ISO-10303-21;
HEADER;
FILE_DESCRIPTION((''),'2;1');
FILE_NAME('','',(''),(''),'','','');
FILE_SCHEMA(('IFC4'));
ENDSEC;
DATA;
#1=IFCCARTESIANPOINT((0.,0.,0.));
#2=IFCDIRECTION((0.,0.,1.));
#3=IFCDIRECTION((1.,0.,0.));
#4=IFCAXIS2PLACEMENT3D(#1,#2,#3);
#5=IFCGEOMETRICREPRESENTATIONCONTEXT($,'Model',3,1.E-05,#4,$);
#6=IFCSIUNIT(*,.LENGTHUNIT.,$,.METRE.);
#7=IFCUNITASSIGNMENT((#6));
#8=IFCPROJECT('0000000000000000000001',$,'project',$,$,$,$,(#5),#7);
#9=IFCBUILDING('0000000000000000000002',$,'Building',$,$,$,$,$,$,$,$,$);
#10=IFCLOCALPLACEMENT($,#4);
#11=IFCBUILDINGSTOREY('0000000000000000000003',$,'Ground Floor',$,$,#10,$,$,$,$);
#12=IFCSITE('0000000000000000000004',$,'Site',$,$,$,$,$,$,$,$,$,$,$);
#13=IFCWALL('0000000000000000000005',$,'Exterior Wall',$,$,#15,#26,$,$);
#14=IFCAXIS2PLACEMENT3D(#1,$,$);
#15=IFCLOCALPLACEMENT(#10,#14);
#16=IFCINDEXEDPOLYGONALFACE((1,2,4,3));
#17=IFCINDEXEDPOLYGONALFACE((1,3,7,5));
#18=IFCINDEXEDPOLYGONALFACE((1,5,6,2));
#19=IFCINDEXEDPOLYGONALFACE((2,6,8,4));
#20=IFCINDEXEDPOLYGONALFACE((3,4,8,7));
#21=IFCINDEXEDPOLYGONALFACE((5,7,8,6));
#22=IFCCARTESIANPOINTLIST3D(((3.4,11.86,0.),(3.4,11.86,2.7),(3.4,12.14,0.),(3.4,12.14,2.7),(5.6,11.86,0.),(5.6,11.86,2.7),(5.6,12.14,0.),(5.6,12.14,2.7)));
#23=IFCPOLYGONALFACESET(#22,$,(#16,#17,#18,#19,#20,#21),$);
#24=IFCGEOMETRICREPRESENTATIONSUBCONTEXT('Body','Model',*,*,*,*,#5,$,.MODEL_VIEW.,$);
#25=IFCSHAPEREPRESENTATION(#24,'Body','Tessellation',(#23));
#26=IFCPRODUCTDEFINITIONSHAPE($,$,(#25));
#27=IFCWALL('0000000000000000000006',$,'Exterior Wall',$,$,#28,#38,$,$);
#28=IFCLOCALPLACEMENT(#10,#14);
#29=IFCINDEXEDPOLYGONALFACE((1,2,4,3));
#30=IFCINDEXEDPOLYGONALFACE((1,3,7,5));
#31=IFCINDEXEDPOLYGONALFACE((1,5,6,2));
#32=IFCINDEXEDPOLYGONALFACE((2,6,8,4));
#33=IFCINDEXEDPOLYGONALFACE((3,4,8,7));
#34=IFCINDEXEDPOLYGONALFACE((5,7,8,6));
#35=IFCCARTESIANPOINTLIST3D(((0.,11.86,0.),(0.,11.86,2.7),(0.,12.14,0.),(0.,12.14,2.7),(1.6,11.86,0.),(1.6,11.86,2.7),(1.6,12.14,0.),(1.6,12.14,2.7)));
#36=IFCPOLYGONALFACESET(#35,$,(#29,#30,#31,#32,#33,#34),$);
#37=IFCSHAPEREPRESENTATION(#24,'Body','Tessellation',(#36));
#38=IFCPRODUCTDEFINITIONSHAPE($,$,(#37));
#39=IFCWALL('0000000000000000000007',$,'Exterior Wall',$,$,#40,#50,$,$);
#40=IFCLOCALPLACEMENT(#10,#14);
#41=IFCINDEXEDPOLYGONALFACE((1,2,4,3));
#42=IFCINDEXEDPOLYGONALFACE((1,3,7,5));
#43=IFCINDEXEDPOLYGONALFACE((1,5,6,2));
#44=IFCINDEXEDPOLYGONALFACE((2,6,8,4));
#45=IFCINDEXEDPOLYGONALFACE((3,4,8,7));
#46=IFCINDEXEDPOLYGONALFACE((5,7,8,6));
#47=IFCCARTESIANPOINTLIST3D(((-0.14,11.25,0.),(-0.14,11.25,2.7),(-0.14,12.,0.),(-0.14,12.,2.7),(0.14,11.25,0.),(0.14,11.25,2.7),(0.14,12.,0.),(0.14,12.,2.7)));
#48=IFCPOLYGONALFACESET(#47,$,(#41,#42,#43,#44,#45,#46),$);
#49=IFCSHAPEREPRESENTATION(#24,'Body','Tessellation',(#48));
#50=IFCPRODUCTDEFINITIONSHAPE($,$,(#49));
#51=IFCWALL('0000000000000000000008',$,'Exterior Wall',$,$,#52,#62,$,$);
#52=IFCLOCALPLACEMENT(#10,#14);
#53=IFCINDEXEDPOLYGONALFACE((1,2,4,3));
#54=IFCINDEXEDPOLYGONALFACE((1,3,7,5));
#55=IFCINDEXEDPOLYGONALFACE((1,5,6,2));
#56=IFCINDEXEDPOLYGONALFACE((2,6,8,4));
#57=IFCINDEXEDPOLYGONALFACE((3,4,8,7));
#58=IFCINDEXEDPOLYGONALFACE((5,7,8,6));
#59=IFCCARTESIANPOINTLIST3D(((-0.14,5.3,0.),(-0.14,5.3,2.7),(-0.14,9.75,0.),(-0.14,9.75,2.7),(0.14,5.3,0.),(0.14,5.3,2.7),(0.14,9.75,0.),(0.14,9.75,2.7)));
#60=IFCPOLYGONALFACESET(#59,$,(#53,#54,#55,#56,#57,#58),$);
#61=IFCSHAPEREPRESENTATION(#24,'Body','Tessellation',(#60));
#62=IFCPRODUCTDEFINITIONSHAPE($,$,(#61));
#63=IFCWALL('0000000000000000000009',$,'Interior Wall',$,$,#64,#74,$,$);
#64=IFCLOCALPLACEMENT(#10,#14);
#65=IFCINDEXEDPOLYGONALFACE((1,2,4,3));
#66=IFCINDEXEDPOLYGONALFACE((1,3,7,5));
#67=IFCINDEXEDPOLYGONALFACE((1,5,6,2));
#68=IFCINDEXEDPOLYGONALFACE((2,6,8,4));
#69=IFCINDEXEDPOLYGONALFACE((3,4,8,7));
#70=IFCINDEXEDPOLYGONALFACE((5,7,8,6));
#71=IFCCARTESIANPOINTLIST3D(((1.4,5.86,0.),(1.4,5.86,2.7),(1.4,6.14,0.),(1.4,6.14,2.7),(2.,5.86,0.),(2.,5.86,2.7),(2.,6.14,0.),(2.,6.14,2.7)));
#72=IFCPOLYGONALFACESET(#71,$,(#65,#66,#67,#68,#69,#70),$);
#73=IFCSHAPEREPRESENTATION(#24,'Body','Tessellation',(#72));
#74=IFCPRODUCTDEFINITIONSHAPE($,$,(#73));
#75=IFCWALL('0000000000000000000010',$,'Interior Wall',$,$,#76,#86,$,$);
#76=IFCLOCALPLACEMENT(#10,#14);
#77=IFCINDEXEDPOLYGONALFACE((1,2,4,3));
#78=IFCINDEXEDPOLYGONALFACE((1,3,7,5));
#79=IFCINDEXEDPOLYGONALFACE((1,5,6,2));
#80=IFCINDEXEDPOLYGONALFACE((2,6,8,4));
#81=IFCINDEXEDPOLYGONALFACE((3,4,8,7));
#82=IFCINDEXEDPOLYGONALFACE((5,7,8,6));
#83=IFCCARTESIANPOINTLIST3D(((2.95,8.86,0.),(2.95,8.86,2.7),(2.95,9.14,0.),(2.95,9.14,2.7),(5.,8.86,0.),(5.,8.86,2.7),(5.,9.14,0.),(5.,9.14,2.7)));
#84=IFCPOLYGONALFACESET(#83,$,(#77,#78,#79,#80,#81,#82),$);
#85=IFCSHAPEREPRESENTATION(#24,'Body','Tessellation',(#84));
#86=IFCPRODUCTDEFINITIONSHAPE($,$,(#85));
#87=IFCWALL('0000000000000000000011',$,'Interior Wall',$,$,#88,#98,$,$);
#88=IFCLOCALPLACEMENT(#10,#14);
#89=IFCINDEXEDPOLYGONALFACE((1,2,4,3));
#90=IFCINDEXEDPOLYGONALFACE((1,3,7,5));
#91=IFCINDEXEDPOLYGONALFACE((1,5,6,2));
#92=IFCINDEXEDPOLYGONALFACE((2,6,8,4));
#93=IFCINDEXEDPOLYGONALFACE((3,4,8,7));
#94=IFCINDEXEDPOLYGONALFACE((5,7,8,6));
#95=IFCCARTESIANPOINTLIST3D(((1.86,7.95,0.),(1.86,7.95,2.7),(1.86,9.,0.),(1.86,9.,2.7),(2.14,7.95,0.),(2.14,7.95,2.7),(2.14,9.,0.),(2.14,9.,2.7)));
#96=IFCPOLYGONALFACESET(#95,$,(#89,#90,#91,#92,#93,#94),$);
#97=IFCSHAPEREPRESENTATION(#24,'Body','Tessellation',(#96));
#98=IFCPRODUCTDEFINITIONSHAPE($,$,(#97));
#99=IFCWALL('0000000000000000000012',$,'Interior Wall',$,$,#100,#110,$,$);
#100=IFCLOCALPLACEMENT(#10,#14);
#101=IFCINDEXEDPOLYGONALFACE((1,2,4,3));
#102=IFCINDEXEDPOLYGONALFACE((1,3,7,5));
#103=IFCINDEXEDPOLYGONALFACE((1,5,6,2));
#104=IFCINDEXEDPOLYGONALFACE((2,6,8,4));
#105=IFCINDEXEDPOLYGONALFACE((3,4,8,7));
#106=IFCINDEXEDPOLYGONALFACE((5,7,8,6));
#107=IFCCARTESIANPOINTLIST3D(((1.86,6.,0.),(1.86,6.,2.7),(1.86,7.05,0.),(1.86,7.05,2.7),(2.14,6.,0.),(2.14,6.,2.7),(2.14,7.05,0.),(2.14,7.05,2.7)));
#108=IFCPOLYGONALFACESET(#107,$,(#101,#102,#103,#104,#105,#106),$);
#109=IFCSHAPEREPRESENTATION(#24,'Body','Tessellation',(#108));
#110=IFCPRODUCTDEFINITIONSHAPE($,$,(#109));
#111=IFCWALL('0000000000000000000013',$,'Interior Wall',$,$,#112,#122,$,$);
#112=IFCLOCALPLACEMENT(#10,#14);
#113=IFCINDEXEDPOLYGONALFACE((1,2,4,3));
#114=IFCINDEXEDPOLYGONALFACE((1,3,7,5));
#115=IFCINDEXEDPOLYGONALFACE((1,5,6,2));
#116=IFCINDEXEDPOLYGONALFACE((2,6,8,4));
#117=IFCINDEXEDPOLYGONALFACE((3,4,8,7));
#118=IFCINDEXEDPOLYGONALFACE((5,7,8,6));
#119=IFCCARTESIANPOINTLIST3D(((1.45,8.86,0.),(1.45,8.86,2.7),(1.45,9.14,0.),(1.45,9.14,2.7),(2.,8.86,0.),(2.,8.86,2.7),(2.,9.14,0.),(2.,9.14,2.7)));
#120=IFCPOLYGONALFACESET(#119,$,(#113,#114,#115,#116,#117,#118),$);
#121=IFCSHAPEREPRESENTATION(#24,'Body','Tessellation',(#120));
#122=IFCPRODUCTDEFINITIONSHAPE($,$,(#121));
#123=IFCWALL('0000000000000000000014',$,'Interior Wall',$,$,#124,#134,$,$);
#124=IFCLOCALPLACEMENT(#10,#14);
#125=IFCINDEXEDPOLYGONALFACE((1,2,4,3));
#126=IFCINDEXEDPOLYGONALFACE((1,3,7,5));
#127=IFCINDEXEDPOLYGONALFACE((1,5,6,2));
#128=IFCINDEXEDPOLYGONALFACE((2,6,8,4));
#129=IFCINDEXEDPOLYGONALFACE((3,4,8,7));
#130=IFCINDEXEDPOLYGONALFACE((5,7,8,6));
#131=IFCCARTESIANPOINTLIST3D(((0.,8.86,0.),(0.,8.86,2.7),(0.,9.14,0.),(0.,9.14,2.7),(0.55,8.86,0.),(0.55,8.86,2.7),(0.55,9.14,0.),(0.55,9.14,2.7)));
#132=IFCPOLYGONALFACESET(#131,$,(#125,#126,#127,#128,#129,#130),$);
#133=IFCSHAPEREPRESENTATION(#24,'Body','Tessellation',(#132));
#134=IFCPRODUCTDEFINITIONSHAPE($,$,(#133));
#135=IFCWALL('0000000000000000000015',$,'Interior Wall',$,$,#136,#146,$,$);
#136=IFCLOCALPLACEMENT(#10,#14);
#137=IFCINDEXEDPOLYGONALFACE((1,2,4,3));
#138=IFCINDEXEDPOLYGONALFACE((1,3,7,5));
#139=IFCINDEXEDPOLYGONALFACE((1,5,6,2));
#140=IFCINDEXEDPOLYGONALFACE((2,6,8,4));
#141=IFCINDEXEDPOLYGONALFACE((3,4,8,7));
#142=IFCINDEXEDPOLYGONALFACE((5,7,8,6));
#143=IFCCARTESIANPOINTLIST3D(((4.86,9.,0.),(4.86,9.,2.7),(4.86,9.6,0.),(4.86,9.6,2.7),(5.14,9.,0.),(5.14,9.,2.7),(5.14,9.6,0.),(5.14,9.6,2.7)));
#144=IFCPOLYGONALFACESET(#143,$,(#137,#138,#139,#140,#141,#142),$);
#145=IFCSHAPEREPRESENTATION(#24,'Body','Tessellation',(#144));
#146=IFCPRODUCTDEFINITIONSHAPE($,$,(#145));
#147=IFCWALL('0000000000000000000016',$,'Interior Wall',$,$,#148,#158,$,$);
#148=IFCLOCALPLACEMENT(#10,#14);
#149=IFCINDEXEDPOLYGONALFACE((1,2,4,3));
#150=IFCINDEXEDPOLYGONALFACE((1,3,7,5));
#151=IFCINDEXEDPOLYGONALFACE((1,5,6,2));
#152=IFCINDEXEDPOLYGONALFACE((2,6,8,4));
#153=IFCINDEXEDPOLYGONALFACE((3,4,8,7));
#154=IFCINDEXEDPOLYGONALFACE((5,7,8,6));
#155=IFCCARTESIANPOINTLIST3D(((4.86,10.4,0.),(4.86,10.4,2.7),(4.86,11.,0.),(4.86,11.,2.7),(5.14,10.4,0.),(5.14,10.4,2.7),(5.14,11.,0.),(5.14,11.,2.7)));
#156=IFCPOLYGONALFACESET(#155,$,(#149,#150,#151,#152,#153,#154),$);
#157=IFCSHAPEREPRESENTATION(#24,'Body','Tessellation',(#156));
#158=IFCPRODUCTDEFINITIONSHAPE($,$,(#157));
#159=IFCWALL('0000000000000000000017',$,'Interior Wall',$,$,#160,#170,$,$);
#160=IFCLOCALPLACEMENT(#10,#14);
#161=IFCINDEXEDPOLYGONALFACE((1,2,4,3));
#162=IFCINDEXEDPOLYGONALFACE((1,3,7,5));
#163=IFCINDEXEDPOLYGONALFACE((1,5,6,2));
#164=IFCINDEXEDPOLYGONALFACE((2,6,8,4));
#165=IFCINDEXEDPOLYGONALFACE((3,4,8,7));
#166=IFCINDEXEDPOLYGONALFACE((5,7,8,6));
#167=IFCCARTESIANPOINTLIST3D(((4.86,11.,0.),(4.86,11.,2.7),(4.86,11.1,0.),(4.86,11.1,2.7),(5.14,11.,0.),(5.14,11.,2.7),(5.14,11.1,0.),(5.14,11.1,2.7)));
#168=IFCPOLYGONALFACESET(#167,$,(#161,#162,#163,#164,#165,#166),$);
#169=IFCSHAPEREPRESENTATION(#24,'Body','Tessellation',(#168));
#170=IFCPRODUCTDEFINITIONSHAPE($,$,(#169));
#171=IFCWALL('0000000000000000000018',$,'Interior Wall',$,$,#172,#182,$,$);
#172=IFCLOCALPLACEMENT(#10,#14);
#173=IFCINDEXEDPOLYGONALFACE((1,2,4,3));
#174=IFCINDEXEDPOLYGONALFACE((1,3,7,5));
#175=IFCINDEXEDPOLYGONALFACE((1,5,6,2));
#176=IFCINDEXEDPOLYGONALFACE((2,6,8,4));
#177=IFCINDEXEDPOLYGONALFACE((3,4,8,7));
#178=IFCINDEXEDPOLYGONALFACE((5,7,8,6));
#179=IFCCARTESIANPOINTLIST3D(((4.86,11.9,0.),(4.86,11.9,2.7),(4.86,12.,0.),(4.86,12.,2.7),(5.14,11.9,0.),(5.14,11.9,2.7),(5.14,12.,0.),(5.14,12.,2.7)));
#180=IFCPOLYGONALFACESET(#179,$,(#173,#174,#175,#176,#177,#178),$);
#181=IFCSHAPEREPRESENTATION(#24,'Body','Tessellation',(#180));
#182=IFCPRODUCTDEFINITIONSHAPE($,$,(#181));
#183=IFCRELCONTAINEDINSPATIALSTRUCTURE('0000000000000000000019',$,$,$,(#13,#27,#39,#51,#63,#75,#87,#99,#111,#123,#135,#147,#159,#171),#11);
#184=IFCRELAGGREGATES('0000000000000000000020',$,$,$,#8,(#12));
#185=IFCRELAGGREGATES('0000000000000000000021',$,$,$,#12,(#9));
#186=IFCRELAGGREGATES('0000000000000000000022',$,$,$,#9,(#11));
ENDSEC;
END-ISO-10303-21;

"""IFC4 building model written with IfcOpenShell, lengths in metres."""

from ifc_helpers import new_model, si_unit, frame, origin_with_axes, place, context, subcontext, project, spatial, indexed_curve, outline, extrude, element, save


model = new_model("IFC4")

# Units and contexts
model_context = context("Model", 3, precision=1e-05, world=origin_with_axes())
body_context = subcontext(model_context, "Body", "Model", "MODEL_VIEW")
ifc_project = project(units=[si_unit("LENGTHUNIT", "METRE")], contexts=[model_context])

# Site, building, storey
site = spatial("IfcSite", under=ifc_project, Name="Site")
building = spatial("IfcBuilding", under=site, Name="Building")
storey_placement = place(None, origin_with_axes())
storey = spatial("IfcBuildingStorey", under=building, at=storey_placement, Name="Ground Floor")

# Walls
wall_1_placement = place(storey_placement, frame((5.6, 12.0, 0.0), z_axis=(0.0, 0.0, 1.0), x_axis=(-1.0, 0.0, 0.0)))
element("IfcWall", 1, at=wall_1_placement, inside=storey, Name="Exterior Wall", context=body_context, shape_type="SweptSolid", body=[
    extrude(outline(indexed_curve([(0.0, 0.0), (0.0, 0.28), (2.2, 0.28), (2.2, 0.0), (0.0, 0.0)], self_intersect=False)), frame((0.0, -0.14, 0.0), z_axis=(0.0, 0.0, 1.0), x_axis=(1.0, 0.0, 0.0)), (0.0, 0.0, 1.0), 2.7),
])
wall_2_placement = place(storey_placement, frame((1.6, 12.0, 0.0), z_axis=(0.0, 0.0, 1.0), x_axis=(-1.0, 0.0, 0.0)))
element("IfcWall", 2, at=wall_2_placement, inside=storey, Name="Exterior Wall", context=body_context, shape_type="SweptSolid", body=[
    extrude(outline(indexed_curve([(0.0, 0.0), (0.0, 0.28), (1.6, 0.28), (1.6, 0.0), (0.0, 0.0)], self_intersect=False)), frame((0.0, -0.14, 0.0), z_axis=(0.0, 0.0, 1.0), x_axis=(1.0, 0.0, 0.0)), (0.0, 0.0, 1.0), 2.7),
])
wall_3_placement = place(storey_placement, frame((0.0, 12.0, 0.0), z_axis=(0.0, 0.0, 1.0), x_axis=(0.0, -1.0, 0.0)))
element("IfcWall", 3, at=wall_3_placement, inside=storey, Name="Exterior Wall", context=body_context, shape_type="SweptSolid", body=[
    extrude(outline(indexed_curve([(0.0, 0.0), (0.0, 0.28), (0.75, 0.28), (0.75, 0.0), (0.0, 0.0)], self_intersect=False)), frame((0.0, -0.14, 0.0), z_axis=(0.0, 0.0, 1.0), x_axis=(1.0, 0.0, 0.0)), (0.0, 0.0, 1.0), 2.7),
])
wall_4_placement = place(storey_placement, frame((0.0, 9.75, 0.0), z_axis=(0.0, 0.0, 1.0), x_axis=(0.0, -1.0, 0.0)))
element("IfcWall", 4, at=wall_4_placement, inside=storey, Name="Exterior Wall", context=body_context, shape_type="SweptSolid", body=[
    extrude(outline(indexed_curve([(0.0, 0.0), (0.0, 0.28), (4.45, 0.28), (4.45, 0.0), (0.0, 0.0)], self_intersect=False)), frame((0.0, -0.14, 0.0), z_axis=(0.0, 0.0, 1.0), x_axis=(1.0, 0.0, 0.0)), (0.0, 0.0, 1.0), 2.7),
])
wall_5_placement = place(storey_placement, frame((2.0, 6.0, 0.0), z_axis=(0.0, 0.0, 1.0), x_axis=(-1.0, 0.0, 0.0)))
element("IfcWall", 5, at=wall_5_placement, inside=storey, Name="Interior Wall", context=body_context, shape_type="SweptSolid", body=[
    extrude(outline(indexed_curve([(0.0, 0.0), (0.0, 0.28), (0.6, 0.28), (0.6, 0.0), (0.0, 0.0)], self_intersect=False)), frame((0.0, -0.14, 0.0), z_axis=(0.0, 0.0, 1.0), x_axis=(1.0, 0.0, 0.0)), (0.0, 0.0, 1.0), 2.7),
])
wall_6_placement = place(storey_placement, frame((5.0, 9.0, 0.0), z_axis=(0.0, 0.0, 1.0), x_axis=(-1.0, 0.0, 0.0)))
element("IfcWall", 6, at=wall_6_placement, inside=storey, Name="Interior Wall", context=body_context, shape_type="SweptSolid", body=[
    extrude(outline(indexed_curve([(0.0, 0.0), (0.0, 0.28), (2.05, 0.28), (2.05, 0.0), (0.0, 0.0)], self_intersect=False)), frame((0.0, -0.14, 0.0), z_axis=(0.0, 0.0, 1.0), x_axis=(1.0, 0.0, 0.0)), (0.0, 0.0, 1.0), 2.7),
])
for number, where, z_axis, x_axis, name in (
    (7, (2.0, 9.0, 0.0), (0.0, 0.0, 1.0), (0.0, -1.0, 0.0), "Interior Wall"),
    (8, (2.0, 7.05, 0.0), (0.0, 0.0, 1.0), (0.0, -1.0, 0.0), "Interior Wall"),
):
    element("IfcWall", number, at=place(storey_placement, frame(where, z_axis=z_axis, x_axis=x_axis)), inside=storey, Name=name, context=body_context, shape_type="SweptSolid", body=[
        extrude(outline(indexed_curve([(0.0, 0.0), (0.0, 0.28), (1.05, 0.28), (1.05, 0.0), (0.0, 0.0)], self_intersect=False)), frame((0.0, -0.14, 0.0), z_axis=(0.0, 0.0, 1.0), x_axis=(1.0, 0.0, 0.0)), (0.0, 0.0, 1.0), 2.7),
    ])
for number, where, z_axis, x_axis, name in (
    (9, (2.0, 9.0, 0.0), (0.0, 0.0, 1.0), (-1.0, 0.0, 0.0), "Interior Wall"),
    (10, (0.55, 9.0, 0.0), (0.0, 0.0, 1.0), (-1.0, 0.0, 0.0), "Interior Wall"),
):
    element("IfcWall", number, at=place(storey_placement, frame(where, z_axis=z_axis, x_axis=x_axis)), inside=storey, Name=name, context=body_context, shape_type="SweptSolid", body=[
        extrude(outline(indexed_curve([(0.0, 0.0), (0.0, 0.28), (0.55, 0.28), (0.55, 0.0), (0.0, 0.0)], self_intersect=False)), frame((0.0, -0.14, 0.0), z_axis=(0.0, 0.0, 1.0), x_axis=(1.0, 0.0, 0.0)), (0.0, 0.0, 1.0), 2.7),
    ])
for number, where, z_axis, x_axis, name in (
    (11, (5.0, 9.0, 0.0), (0.0, 0.0, 1.0), (0.0, 1.0, 0.0), "Interior Wall"),
    (12, (5.0, 10.4, 0.0), (0.0, 0.0, 1.0), (0.0, 1.0, 0.0), "Interior Wall"),
):
    element("IfcWall", number, at=place(storey_placement, frame(where, z_axis=z_axis, x_axis=x_axis)), inside=storey, Name=name, context=body_context, shape_type="SweptSolid", body=[
        extrude(outline(indexed_curve([(0.0, 0.0), (0.0, 0.28), (0.6, 0.28), (0.6, 0.0), (0.0, 0.0)], self_intersect=False)), frame((0.0, -0.14, 0.0), z_axis=(0.0, 0.0, 1.0), x_axis=(1.0, 0.0, 0.0)), (0.0, 0.0, 1.0), 2.7),
    ])
for number, where, z_axis, x_axis, name in (
    (13, (5.0, 11.0, 0.0), (0.0, 0.0, 1.0), (0.0, 1.0, 0.0), "Interior Wall"),
    (14, (5.0, 11.9, 0.0), (0.0, 0.0, 1.0), (0.0, 1.0, 0.0), "Interior Wall"),
):
    element("IfcWall", number, at=place(storey_placement, frame(where, z_axis=z_axis, x_axis=x_axis)), inside=storey, Name=name, context=body_context, shape_type="SweptSolid", body=[
        extrude(outline(indexed_curve([(0.0, 0.0), (0.0, 0.28), (0.1, 0.28), (0.1, 0.0), (0.0, 0.0)], self_intersect=False)), frame((0.0, -0.14, 0.0), z_axis=(0.0, 0.0, 1.0), x_axis=(1.0, 0.0, 0.0)), (0.0, 0.0, 1.0), 2.7),
    ])

save(model, "model.ifc")
